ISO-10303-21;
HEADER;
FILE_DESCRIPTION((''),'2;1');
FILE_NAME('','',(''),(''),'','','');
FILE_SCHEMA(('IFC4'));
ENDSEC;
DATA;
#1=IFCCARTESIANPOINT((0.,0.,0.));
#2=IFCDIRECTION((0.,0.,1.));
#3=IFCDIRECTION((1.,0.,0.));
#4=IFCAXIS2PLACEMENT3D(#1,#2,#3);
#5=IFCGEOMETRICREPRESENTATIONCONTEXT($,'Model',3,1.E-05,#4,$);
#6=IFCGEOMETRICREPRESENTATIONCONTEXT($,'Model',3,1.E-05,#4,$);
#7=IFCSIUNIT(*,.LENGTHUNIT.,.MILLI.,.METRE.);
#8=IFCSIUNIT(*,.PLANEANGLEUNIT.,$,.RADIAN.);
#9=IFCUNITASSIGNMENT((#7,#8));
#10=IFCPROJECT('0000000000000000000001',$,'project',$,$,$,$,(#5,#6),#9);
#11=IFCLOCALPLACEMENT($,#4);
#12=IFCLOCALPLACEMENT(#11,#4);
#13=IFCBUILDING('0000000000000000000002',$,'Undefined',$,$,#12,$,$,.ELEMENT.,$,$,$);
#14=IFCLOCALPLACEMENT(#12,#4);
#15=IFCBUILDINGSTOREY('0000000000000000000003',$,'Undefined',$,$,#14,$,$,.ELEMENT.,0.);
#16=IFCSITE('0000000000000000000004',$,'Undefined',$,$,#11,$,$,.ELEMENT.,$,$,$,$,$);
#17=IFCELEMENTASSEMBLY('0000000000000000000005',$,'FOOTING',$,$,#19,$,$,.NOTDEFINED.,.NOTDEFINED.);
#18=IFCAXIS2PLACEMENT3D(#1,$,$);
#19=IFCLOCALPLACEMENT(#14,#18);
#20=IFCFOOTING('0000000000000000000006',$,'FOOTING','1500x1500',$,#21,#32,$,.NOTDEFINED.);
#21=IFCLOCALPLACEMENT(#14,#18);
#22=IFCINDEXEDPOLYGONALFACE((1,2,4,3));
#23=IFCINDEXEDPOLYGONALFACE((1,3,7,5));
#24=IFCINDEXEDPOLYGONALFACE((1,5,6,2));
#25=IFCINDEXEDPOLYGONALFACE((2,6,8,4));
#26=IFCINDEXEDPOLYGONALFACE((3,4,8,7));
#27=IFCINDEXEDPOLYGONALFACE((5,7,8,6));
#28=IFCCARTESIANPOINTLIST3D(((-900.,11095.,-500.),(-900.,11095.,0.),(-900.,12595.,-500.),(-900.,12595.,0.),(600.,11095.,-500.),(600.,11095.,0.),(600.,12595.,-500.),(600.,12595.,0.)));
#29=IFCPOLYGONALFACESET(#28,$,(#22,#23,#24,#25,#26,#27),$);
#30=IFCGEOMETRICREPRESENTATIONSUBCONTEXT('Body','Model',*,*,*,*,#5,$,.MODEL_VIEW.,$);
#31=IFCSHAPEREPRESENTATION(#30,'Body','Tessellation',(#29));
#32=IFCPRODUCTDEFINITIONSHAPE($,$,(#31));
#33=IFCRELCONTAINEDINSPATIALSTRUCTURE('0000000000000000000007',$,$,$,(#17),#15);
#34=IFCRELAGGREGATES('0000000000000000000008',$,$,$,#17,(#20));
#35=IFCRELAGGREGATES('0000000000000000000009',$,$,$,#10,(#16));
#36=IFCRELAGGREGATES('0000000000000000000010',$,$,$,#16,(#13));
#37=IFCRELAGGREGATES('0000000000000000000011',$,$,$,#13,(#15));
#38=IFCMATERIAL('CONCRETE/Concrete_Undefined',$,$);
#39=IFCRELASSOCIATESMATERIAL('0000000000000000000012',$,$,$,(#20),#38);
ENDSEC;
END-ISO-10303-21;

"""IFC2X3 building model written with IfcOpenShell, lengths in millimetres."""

from ifc_helpers import new_model, si_unit, frame, origin_with_axes, origin_2d_with_axis, place, context, subcontext, project, spatial, rectangle, extrude, material, element, aggregate, save


model = new_model("IFC2X3")

# Units and contexts
model_context_1 = context("Model", 3, precision=1e-05, world=origin_with_axes())
model_context_2 = context("Model", 3, precision=1e-05, world=origin_with_axes())
body_context = subcontext(model_context_1, "Body", "Model", "MODEL_VIEW")
ifc_project = project(units=[si_unit("LENGTHUNIT", "METRE", prefix="MILLI"), si_unit("PLANEANGLEUNIT", "RADIAN")], contexts=[model_context_1, model_context_2])

# Site, building, storey
site_placement = place(None, origin_with_axes())
site = spatial("IfcSite", under=ifc_project, at=site_placement, Name="Undefined", CompositionType="ELEMENT")
building_placement = place(site_placement, origin_with_axes())
building = spatial("IfcBuilding", under=site, at=building_placement, Name="Undefined", CompositionType="ELEMENT")
storey_placement = place(building_placement, origin_with_axes())
storey = spatial("IfcBuildingStorey", under=building, at=storey_placement, Name="Undefined", CompositionType="ELEMENT", Elevation=0.0)

# Element assembly, footing
assembly_1_placement = place(storey_placement, origin_with_axes())
assembly_1 = element("IfcElementAssembly", 1, at=assembly_1_placement, inside=storey, Name="FOOTING", AssemblyPlace="NOTDEFINED", PredefinedType="NOTDEFINED")
ifc_material_1 = material(Name="CONCRETE/Concrete_Undefined")
footing_placement = place(assembly_1_placement, frame((-150.0, 11845.0, -500.0), z_axis=(0.0, 1.0, 0.0), x_axis=(0.0, 0.0, 1.0)))
footing = element("IfcFooting", 2, at=footing_placement, material=ifc_material_1, Name="FOOTING", Description="1500x1500", PredefinedType="NOTDEFINED", context=body_context, shape_type="SweptSolid", body=[
    extrude(rectangle(XDim=1500.0, YDim=1500.0, at=origin_2d_with_axis()), frame((500.0, 0.0, 0.0), z_axis=(-1.0, 0.0, 0.0), x_axis=(0.0, -1.0, 0.0)), (0.0, 0.0, 1.0), 500.0),
])
aggregate(assembly_1, [footing])

save(model, "model.ifc")
